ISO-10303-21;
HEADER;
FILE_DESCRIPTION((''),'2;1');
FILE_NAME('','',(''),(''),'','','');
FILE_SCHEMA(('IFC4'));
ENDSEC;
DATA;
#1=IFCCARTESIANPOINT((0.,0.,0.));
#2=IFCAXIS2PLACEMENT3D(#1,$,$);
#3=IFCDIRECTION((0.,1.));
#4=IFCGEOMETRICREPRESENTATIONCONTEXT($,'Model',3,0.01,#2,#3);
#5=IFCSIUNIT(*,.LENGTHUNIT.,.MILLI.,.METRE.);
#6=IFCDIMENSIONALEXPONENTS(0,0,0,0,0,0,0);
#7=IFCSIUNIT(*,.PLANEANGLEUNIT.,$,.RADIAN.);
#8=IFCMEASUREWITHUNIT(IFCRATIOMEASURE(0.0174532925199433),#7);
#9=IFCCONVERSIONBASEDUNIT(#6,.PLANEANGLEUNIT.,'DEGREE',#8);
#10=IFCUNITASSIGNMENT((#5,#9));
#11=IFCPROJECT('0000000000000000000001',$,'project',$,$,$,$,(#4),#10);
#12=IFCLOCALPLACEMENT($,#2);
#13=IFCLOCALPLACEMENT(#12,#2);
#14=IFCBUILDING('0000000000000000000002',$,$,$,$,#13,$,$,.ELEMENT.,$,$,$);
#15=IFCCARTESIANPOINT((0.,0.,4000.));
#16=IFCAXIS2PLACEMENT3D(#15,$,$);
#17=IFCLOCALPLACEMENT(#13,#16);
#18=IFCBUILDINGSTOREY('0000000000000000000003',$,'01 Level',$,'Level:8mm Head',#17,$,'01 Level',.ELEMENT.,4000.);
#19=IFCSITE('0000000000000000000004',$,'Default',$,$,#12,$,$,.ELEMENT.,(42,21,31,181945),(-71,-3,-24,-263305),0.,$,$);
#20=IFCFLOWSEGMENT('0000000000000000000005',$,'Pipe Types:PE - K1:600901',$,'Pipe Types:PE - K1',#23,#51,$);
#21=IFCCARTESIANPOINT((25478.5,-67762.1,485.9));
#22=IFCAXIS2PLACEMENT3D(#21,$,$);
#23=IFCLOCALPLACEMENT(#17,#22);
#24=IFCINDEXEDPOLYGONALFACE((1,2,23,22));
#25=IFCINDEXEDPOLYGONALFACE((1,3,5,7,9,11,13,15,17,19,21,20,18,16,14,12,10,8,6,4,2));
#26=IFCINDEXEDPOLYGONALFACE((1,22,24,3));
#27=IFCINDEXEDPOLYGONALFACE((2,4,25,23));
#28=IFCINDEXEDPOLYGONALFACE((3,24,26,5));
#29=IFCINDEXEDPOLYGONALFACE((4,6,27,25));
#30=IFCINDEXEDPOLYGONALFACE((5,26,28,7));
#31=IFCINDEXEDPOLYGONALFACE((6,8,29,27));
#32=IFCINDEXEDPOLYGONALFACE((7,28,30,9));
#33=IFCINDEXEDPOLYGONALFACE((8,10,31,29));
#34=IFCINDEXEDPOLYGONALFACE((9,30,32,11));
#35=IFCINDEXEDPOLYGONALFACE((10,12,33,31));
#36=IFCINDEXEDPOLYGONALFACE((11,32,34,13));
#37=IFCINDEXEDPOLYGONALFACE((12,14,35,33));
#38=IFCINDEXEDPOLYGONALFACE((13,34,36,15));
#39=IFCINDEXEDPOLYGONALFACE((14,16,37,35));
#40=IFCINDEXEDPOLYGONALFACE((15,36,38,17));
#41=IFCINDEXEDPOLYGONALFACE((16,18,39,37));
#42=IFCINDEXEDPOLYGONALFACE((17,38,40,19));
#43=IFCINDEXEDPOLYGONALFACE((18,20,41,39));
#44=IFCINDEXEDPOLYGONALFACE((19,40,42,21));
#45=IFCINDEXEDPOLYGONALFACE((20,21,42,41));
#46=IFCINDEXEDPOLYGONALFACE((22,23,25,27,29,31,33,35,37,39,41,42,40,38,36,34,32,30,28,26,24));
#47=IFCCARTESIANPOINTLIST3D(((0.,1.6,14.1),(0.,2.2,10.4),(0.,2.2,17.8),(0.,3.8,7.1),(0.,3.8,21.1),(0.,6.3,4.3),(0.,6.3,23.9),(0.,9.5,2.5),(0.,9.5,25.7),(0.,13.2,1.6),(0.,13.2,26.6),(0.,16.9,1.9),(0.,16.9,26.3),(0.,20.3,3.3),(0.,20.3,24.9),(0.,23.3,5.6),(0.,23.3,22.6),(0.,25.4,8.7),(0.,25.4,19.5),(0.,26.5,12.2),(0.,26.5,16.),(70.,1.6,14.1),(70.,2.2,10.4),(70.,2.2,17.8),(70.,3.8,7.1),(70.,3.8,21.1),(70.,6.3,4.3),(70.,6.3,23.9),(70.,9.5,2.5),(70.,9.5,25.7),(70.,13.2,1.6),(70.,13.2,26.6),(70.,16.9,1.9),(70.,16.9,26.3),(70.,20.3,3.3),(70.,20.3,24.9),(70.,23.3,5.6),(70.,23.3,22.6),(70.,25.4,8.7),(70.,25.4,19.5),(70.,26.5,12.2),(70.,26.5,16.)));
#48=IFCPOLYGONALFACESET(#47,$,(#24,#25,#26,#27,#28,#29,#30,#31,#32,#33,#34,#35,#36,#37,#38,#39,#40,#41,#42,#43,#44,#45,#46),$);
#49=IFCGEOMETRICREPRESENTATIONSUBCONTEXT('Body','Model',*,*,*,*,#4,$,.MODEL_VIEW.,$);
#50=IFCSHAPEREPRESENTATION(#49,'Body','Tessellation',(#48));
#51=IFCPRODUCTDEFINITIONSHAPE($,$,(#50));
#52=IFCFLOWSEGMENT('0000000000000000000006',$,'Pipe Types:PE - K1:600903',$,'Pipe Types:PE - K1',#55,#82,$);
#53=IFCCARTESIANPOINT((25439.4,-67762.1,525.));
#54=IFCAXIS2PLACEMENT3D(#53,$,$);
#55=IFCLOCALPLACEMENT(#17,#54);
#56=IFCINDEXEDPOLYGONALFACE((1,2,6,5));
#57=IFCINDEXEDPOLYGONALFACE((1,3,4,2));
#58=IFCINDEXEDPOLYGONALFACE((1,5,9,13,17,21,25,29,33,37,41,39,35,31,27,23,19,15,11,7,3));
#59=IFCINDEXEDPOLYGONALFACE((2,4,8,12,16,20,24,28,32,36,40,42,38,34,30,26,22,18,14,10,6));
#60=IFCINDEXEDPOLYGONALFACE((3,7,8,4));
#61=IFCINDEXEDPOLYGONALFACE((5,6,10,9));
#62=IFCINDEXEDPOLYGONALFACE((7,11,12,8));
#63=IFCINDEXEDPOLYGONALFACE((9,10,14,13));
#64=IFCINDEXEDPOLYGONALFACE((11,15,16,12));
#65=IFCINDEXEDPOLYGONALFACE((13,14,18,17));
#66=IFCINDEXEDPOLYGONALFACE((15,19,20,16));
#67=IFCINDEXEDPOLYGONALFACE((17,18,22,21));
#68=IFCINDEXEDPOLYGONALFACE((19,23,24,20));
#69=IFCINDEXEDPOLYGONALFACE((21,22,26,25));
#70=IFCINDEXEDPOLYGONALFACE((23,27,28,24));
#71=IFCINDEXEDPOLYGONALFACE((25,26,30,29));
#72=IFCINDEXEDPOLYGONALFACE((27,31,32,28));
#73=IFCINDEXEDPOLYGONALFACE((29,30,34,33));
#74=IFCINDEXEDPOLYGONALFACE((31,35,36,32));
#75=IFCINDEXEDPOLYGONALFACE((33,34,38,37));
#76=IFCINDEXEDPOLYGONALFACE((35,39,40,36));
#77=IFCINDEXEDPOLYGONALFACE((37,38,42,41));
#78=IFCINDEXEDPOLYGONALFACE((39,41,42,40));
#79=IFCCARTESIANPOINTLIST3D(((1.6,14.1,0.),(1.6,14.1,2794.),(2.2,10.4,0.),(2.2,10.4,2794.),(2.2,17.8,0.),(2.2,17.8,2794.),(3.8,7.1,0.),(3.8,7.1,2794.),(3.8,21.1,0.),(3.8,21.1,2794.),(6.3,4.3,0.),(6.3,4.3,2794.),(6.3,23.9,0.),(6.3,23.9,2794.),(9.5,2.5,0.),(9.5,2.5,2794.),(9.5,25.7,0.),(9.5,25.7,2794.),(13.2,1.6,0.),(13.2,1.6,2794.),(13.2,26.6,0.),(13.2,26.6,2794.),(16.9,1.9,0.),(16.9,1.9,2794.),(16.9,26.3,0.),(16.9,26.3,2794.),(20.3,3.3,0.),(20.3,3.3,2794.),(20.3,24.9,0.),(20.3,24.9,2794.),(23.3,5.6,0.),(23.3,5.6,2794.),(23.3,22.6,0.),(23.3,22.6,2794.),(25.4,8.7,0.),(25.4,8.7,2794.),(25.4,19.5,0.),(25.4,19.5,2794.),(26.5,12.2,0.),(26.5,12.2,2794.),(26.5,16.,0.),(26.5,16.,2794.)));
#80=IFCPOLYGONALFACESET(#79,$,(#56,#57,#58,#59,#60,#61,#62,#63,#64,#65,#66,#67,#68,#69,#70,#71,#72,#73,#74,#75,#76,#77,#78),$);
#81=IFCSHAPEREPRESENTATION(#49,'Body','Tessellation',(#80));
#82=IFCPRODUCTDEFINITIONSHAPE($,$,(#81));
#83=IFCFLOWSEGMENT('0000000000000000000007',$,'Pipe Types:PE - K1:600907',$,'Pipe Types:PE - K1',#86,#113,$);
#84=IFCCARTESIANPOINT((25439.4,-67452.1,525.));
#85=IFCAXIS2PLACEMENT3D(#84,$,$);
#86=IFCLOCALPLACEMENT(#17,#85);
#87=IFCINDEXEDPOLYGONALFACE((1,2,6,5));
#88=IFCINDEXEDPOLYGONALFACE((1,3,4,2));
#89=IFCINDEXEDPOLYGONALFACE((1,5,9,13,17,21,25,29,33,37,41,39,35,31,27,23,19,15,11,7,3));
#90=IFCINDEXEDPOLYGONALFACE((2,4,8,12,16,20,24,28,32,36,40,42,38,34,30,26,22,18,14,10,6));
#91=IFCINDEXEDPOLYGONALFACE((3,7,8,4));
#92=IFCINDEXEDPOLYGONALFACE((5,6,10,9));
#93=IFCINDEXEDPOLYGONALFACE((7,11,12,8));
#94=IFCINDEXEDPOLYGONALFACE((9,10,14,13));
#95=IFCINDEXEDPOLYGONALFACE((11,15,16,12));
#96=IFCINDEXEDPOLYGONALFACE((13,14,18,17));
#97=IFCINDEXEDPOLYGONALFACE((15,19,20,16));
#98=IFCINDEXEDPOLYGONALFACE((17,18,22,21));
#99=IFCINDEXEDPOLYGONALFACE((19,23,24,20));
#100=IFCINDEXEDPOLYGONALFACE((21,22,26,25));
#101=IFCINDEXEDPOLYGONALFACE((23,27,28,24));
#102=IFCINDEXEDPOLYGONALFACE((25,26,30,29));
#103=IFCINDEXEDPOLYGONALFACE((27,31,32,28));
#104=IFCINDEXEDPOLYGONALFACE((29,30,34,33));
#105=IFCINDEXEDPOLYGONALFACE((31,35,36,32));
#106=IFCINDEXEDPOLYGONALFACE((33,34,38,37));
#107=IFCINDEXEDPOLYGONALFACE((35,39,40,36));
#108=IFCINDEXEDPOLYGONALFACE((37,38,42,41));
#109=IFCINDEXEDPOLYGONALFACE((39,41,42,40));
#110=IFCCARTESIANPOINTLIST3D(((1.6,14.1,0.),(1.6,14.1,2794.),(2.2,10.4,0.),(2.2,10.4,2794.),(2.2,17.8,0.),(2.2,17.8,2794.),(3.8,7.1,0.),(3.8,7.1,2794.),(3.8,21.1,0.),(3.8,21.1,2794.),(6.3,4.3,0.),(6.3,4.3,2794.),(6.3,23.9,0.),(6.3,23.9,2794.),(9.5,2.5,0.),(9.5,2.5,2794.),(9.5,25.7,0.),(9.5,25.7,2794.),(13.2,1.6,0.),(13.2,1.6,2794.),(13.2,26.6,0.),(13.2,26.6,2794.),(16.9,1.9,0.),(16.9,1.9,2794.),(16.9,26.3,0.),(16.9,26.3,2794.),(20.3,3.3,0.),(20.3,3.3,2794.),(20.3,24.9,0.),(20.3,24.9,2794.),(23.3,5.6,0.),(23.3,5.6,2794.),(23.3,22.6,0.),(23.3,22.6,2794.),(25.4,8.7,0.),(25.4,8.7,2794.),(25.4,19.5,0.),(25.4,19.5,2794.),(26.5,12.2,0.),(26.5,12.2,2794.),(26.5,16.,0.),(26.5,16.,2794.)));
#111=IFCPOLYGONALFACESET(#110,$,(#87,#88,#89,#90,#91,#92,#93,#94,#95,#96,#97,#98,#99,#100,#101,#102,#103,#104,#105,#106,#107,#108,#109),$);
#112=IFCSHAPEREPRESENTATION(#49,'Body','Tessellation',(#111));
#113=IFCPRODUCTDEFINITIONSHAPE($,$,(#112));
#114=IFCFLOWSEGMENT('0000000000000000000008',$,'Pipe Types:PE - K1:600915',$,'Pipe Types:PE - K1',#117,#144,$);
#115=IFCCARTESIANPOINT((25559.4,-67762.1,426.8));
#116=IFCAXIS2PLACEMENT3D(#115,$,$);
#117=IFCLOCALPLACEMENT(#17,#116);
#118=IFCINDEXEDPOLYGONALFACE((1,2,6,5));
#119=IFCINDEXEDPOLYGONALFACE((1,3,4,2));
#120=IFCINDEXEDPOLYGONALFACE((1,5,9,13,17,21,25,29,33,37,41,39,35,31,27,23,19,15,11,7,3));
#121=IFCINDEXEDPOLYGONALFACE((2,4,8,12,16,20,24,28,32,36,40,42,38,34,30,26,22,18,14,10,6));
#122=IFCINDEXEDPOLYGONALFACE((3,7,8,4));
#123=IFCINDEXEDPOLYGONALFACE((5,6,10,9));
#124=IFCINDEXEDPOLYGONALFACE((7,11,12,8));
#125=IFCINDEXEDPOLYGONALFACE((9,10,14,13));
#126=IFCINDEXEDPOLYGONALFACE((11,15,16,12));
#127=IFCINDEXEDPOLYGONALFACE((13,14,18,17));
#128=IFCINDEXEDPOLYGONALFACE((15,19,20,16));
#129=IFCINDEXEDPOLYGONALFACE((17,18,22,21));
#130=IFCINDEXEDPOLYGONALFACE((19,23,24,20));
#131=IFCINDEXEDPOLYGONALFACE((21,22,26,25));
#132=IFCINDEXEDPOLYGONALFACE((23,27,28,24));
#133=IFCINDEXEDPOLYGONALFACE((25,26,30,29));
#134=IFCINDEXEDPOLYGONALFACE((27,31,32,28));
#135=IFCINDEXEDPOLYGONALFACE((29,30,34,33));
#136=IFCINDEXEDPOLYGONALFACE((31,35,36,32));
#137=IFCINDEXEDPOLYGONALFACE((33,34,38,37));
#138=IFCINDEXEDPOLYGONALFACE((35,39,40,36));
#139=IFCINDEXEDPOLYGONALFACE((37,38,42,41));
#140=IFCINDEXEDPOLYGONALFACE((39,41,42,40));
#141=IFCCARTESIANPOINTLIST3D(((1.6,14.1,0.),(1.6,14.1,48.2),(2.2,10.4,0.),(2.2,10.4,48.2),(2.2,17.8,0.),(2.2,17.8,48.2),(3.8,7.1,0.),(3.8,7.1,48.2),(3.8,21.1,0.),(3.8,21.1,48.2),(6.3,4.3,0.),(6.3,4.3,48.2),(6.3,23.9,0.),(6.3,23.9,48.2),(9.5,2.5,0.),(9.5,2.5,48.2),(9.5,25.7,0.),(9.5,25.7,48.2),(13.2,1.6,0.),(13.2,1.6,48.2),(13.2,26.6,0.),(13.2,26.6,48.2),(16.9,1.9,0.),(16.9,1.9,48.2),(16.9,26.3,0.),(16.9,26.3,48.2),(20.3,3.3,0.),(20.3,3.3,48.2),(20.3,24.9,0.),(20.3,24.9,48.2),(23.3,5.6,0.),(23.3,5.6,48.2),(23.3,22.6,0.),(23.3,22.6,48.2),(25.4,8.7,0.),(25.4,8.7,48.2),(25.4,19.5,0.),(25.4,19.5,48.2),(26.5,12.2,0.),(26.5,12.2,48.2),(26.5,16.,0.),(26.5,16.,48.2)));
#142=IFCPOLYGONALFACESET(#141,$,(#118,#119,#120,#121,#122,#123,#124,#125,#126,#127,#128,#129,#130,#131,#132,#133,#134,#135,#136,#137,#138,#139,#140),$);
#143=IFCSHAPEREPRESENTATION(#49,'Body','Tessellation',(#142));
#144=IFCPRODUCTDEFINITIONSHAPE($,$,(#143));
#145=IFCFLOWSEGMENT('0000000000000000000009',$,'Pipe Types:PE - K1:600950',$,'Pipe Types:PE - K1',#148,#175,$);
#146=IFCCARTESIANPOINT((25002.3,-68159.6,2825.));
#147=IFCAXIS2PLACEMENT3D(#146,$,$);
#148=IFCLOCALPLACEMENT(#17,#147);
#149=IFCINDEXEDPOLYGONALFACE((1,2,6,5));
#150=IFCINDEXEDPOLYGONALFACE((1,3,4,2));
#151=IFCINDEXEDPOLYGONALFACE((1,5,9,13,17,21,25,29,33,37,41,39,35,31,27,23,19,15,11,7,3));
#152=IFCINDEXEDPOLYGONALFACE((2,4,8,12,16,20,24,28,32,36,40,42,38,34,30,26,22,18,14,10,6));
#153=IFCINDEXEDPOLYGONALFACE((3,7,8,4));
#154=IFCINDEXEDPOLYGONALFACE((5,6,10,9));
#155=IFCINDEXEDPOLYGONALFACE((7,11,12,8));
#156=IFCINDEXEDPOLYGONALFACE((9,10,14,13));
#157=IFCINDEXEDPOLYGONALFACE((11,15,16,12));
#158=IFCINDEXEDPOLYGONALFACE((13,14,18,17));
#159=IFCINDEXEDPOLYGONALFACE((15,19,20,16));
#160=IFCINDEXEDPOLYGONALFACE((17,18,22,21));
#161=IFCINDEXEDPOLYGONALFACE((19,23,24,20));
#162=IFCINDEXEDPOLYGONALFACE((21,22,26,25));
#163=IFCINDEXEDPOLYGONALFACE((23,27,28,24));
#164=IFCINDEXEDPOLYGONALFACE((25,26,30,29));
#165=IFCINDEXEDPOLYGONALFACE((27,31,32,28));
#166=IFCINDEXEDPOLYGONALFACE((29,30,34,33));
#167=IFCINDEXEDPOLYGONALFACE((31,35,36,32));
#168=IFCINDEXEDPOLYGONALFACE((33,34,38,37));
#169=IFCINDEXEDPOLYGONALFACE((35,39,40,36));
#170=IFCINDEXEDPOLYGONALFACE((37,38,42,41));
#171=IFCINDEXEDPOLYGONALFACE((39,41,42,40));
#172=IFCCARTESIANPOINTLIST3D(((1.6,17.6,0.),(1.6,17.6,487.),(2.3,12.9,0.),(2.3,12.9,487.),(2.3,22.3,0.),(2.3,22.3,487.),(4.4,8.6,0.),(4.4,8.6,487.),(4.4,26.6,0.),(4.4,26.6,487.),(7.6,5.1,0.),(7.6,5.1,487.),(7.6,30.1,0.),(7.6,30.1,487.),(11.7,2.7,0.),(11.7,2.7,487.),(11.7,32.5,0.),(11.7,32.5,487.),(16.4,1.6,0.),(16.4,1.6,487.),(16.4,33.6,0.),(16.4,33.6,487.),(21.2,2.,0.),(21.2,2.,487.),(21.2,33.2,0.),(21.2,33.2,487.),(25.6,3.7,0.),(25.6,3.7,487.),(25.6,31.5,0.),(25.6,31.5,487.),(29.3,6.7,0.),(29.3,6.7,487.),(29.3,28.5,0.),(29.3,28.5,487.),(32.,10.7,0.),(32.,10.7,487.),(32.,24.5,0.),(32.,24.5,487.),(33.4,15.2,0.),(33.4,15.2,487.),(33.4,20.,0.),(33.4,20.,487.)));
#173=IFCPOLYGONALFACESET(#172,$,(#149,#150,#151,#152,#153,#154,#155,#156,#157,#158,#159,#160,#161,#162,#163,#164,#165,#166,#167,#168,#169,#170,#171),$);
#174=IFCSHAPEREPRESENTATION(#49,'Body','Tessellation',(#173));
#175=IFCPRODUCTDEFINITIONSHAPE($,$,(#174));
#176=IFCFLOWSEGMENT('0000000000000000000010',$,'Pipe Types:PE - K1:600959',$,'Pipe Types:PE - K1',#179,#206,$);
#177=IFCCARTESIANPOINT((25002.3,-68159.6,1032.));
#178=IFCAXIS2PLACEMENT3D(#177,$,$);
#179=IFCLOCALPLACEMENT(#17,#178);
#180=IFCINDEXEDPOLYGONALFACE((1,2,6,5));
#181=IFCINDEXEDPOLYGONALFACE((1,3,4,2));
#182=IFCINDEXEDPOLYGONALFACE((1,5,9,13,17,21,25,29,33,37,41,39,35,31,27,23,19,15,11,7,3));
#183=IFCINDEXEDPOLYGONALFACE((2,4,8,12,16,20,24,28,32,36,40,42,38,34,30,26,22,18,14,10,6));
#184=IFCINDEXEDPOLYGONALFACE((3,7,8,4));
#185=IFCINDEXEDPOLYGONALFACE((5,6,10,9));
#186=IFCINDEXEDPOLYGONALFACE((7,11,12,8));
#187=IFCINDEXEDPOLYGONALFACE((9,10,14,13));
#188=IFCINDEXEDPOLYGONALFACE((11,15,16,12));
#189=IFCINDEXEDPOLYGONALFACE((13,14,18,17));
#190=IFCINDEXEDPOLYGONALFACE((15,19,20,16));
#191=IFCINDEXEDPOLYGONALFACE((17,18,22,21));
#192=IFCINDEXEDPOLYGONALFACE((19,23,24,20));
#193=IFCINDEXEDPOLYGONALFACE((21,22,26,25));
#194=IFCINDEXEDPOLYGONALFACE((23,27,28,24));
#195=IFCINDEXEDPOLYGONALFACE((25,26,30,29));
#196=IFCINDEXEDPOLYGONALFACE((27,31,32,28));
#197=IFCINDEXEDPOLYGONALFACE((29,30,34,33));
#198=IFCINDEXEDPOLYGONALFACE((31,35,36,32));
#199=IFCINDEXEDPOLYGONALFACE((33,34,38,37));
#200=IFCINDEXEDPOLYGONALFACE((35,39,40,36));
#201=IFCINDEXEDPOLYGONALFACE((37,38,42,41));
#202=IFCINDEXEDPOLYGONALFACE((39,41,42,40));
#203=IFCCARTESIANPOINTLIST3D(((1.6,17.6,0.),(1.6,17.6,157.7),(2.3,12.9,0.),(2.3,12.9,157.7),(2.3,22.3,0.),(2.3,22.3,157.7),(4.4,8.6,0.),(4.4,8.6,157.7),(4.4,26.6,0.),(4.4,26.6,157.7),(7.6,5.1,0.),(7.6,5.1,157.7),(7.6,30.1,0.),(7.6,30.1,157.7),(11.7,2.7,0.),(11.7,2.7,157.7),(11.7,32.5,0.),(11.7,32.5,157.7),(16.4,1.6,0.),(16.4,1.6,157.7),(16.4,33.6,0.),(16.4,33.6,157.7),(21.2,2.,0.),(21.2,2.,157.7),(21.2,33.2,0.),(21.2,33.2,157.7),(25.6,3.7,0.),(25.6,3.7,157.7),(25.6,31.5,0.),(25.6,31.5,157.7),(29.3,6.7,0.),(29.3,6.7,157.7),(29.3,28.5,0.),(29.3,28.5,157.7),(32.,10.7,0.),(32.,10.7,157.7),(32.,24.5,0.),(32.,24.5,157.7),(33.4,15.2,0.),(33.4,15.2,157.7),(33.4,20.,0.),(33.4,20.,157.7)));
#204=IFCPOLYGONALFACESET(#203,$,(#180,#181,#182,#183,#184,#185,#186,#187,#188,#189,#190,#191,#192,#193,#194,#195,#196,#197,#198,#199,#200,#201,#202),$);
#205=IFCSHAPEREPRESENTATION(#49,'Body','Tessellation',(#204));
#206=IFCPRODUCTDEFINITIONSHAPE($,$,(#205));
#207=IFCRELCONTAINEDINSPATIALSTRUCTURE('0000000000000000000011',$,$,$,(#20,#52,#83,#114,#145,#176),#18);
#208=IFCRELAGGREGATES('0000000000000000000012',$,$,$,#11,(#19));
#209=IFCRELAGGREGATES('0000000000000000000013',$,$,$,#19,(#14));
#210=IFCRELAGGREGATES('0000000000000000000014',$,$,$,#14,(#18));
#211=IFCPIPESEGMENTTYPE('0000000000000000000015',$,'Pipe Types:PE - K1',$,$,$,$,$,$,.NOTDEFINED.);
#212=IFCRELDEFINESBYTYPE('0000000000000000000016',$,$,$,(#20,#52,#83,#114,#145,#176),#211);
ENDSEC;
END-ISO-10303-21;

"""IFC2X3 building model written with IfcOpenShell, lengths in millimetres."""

from ifc_helpers import new_model, entity, si_unit, converted_unit, direction, frame, frame_2d, origin, origin_2d_with_axis, place, context, subcontext, project, spatial, circle, extrude, type_object, element, save


model = new_model("IFC2X3")

# Units and contexts
model_context = context("Model", 3, precision=0.01, world=origin(), true_north=direction((0.0, 1.0)))
body_context = subcontext(model_context, "Body", "Model", "MODEL_VIEW")
ifc_project = project(units=[si_unit("LENGTHUNIT", "METRE", prefix="MILLI"), converted_unit("PLANEANGLEUNIT", "DEGREE", entity("IfcRatioMeasure", 0.0174532925199433), si_unit("PLANEANGLEUNIT", "RADIAN"), dimensions=[0, 0, 0, 0, 0, 0, 0])], contexts=[model_context])

# Site, building, storey
site_placement = place(None, origin())
site = spatial("IfcSite", under=ifc_project, at=site_placement, Name="Default", CompositionType="ELEMENT", RefLatitude=(42, 21, 31, 181945), RefLongitude=(-71, -3, -24, -263305), RefElevation=0.0)
building_placement = place(site_placement, origin())
building = spatial("IfcBuilding", under=site, at=building_placement, CompositionType="ELEMENT")
storey_placement = place(building_placement, frame((0.0, 0.0, 4000.0)))
storey = spatial("IfcBuildingStorey", under=building, at=storey_placement, Name="01 Level", ObjectType="Level:8mm Head", LongName="01 Level", CompositionType="ELEMENT", Elevation=4000.0)

# Flow segments
pipe_segment_type = type_object("IfcPipeSegmentType", Name="Pipe Types:PE - K1", PredefinedType="NOTDEFINED")
flow_segment_1_placement = place(storey_placement, frame((25478.5, -67762.1, 485.9)))
element("IfcFlowSegment", 1, at=flow_segment_1_placement, inside=storey, type_object=pipe_segment_type, Name="Pipe Types:PE - K1:600901", ObjectType="Pipe Types:PE - K1", context=body_context, shape_type="SweptSolid", body=[
    extrude(circle(Radius=12.5, at=frame_2d((0.0, 0.0), x_axis=(1.0, 0.0))), frame((0.0, 14.1, 14.1), z_axis=(1.0, 0.0, 0.0), x_axis=(0.0, -1.0, 0.0)), (0.0, 0.0, 1.0), 70.0),
])
flow_segment_2_placement = place(storey_placement, frame((25439.4, -67762.1, 525.0)))
element("IfcFlowSegment", 2, at=flow_segment_2_placement, inside=storey, type_object=pipe_segment_type, Name="Pipe Types:PE - K1:600903", ObjectType="Pipe Types:PE - K1", context=body_context, shape_type="SweptSolid", body=[
    extrude(circle(Radius=12.5, at=origin_2d_with_axis()), frame((14.1, 14.1, 0.0), z_axis=(0.0, 0.0, 1.0), x_axis=(-1.0, 0.0, 0.0)), (0.0, 0.0, 1.0), 2794.0),
])
flow_segment_3_placement = place(storey_placement, frame((25439.4, -67452.1, 525.0)))
element("IfcFlowSegment", 3, at=flow_segment_3_placement, inside=storey, type_object=pipe_segment_type, Name="Pipe Types:PE - K1:600907", ObjectType="Pipe Types:PE - K1", context=body_context, shape_type="SweptSolid", body=[
    extrude(circle(Radius=12.5, at=origin_2d_with_axis()), frame((14.1, 14.1, 0.0), z_axis=(0.0, 0.0, 1.0), x_axis=(-1.0, 0.0, 0.0)), (0.0, 0.0, 1.0), 2794.0),
])
flow_segment_4_placement = place(storey_placement, frame((25559.4, -67762.1, 426.8)))
element("IfcFlowSegment", 4, at=flow_segment_4_placement, inside=storey, type_object=pipe_segment_type, Name="Pipe Types:PE - K1:600915", ObjectType="Pipe Types:PE - K1", context=body_context, shape_type="SweptSolid", body=[
    extrude(circle(Radius=12.5, at=origin_2d_with_axis()), frame((14.1, 14.1, 0.0), z_axis=(0.0, 0.0, 1.0), x_axis=(-1.0, 0.0, 0.0)), (0.0, 0.0, 1.0), 48.2),
])
flow_segment_5_placement = place(storey_placement, frame((25002.3, -68159.6, 2825.0)))
element("IfcFlowSegment", 5, at=flow_segment_5_placement, inside=storey, type_object=pipe_segment_type, Name="Pipe Types:PE - K1:600950", ObjectType="Pipe Types:PE - K1", context=body_context, shape_type="SweptSolid", body=[
    extrude(circle(Radius=16.0, at=origin_2d_with_axis()), frame((17.6, 17.6, 0.0), z_axis=(0.0, 0.0, 1.0), x_axis=(-1.0, 0.0, 0.0)), (0.0, 0.0, 1.0), 487.0),
])
flow_segment_6_placement = place(storey_placement, frame((25002.3, -68159.6, 1032.0)))
element("IfcFlowSegment", 6, at=flow_segment_6_placement, inside=storey, type_object=pipe_segment_type, Name="Pipe Types:PE - K1:600959", ObjectType="Pipe Types:PE - K1", context=body_context, shape_type="SweptSolid", body=[
    extrude(circle(Radius=16.0, at=origin_2d_with_axis()), frame((17.6, 17.6, 0.0), z_axis=(0.0, 0.0, 1.0), x_axis=(-1.0, 0.0, 0.0)), (0.0, 0.0, 1.0), 157.7),
])

save(model, "model.ifc")
